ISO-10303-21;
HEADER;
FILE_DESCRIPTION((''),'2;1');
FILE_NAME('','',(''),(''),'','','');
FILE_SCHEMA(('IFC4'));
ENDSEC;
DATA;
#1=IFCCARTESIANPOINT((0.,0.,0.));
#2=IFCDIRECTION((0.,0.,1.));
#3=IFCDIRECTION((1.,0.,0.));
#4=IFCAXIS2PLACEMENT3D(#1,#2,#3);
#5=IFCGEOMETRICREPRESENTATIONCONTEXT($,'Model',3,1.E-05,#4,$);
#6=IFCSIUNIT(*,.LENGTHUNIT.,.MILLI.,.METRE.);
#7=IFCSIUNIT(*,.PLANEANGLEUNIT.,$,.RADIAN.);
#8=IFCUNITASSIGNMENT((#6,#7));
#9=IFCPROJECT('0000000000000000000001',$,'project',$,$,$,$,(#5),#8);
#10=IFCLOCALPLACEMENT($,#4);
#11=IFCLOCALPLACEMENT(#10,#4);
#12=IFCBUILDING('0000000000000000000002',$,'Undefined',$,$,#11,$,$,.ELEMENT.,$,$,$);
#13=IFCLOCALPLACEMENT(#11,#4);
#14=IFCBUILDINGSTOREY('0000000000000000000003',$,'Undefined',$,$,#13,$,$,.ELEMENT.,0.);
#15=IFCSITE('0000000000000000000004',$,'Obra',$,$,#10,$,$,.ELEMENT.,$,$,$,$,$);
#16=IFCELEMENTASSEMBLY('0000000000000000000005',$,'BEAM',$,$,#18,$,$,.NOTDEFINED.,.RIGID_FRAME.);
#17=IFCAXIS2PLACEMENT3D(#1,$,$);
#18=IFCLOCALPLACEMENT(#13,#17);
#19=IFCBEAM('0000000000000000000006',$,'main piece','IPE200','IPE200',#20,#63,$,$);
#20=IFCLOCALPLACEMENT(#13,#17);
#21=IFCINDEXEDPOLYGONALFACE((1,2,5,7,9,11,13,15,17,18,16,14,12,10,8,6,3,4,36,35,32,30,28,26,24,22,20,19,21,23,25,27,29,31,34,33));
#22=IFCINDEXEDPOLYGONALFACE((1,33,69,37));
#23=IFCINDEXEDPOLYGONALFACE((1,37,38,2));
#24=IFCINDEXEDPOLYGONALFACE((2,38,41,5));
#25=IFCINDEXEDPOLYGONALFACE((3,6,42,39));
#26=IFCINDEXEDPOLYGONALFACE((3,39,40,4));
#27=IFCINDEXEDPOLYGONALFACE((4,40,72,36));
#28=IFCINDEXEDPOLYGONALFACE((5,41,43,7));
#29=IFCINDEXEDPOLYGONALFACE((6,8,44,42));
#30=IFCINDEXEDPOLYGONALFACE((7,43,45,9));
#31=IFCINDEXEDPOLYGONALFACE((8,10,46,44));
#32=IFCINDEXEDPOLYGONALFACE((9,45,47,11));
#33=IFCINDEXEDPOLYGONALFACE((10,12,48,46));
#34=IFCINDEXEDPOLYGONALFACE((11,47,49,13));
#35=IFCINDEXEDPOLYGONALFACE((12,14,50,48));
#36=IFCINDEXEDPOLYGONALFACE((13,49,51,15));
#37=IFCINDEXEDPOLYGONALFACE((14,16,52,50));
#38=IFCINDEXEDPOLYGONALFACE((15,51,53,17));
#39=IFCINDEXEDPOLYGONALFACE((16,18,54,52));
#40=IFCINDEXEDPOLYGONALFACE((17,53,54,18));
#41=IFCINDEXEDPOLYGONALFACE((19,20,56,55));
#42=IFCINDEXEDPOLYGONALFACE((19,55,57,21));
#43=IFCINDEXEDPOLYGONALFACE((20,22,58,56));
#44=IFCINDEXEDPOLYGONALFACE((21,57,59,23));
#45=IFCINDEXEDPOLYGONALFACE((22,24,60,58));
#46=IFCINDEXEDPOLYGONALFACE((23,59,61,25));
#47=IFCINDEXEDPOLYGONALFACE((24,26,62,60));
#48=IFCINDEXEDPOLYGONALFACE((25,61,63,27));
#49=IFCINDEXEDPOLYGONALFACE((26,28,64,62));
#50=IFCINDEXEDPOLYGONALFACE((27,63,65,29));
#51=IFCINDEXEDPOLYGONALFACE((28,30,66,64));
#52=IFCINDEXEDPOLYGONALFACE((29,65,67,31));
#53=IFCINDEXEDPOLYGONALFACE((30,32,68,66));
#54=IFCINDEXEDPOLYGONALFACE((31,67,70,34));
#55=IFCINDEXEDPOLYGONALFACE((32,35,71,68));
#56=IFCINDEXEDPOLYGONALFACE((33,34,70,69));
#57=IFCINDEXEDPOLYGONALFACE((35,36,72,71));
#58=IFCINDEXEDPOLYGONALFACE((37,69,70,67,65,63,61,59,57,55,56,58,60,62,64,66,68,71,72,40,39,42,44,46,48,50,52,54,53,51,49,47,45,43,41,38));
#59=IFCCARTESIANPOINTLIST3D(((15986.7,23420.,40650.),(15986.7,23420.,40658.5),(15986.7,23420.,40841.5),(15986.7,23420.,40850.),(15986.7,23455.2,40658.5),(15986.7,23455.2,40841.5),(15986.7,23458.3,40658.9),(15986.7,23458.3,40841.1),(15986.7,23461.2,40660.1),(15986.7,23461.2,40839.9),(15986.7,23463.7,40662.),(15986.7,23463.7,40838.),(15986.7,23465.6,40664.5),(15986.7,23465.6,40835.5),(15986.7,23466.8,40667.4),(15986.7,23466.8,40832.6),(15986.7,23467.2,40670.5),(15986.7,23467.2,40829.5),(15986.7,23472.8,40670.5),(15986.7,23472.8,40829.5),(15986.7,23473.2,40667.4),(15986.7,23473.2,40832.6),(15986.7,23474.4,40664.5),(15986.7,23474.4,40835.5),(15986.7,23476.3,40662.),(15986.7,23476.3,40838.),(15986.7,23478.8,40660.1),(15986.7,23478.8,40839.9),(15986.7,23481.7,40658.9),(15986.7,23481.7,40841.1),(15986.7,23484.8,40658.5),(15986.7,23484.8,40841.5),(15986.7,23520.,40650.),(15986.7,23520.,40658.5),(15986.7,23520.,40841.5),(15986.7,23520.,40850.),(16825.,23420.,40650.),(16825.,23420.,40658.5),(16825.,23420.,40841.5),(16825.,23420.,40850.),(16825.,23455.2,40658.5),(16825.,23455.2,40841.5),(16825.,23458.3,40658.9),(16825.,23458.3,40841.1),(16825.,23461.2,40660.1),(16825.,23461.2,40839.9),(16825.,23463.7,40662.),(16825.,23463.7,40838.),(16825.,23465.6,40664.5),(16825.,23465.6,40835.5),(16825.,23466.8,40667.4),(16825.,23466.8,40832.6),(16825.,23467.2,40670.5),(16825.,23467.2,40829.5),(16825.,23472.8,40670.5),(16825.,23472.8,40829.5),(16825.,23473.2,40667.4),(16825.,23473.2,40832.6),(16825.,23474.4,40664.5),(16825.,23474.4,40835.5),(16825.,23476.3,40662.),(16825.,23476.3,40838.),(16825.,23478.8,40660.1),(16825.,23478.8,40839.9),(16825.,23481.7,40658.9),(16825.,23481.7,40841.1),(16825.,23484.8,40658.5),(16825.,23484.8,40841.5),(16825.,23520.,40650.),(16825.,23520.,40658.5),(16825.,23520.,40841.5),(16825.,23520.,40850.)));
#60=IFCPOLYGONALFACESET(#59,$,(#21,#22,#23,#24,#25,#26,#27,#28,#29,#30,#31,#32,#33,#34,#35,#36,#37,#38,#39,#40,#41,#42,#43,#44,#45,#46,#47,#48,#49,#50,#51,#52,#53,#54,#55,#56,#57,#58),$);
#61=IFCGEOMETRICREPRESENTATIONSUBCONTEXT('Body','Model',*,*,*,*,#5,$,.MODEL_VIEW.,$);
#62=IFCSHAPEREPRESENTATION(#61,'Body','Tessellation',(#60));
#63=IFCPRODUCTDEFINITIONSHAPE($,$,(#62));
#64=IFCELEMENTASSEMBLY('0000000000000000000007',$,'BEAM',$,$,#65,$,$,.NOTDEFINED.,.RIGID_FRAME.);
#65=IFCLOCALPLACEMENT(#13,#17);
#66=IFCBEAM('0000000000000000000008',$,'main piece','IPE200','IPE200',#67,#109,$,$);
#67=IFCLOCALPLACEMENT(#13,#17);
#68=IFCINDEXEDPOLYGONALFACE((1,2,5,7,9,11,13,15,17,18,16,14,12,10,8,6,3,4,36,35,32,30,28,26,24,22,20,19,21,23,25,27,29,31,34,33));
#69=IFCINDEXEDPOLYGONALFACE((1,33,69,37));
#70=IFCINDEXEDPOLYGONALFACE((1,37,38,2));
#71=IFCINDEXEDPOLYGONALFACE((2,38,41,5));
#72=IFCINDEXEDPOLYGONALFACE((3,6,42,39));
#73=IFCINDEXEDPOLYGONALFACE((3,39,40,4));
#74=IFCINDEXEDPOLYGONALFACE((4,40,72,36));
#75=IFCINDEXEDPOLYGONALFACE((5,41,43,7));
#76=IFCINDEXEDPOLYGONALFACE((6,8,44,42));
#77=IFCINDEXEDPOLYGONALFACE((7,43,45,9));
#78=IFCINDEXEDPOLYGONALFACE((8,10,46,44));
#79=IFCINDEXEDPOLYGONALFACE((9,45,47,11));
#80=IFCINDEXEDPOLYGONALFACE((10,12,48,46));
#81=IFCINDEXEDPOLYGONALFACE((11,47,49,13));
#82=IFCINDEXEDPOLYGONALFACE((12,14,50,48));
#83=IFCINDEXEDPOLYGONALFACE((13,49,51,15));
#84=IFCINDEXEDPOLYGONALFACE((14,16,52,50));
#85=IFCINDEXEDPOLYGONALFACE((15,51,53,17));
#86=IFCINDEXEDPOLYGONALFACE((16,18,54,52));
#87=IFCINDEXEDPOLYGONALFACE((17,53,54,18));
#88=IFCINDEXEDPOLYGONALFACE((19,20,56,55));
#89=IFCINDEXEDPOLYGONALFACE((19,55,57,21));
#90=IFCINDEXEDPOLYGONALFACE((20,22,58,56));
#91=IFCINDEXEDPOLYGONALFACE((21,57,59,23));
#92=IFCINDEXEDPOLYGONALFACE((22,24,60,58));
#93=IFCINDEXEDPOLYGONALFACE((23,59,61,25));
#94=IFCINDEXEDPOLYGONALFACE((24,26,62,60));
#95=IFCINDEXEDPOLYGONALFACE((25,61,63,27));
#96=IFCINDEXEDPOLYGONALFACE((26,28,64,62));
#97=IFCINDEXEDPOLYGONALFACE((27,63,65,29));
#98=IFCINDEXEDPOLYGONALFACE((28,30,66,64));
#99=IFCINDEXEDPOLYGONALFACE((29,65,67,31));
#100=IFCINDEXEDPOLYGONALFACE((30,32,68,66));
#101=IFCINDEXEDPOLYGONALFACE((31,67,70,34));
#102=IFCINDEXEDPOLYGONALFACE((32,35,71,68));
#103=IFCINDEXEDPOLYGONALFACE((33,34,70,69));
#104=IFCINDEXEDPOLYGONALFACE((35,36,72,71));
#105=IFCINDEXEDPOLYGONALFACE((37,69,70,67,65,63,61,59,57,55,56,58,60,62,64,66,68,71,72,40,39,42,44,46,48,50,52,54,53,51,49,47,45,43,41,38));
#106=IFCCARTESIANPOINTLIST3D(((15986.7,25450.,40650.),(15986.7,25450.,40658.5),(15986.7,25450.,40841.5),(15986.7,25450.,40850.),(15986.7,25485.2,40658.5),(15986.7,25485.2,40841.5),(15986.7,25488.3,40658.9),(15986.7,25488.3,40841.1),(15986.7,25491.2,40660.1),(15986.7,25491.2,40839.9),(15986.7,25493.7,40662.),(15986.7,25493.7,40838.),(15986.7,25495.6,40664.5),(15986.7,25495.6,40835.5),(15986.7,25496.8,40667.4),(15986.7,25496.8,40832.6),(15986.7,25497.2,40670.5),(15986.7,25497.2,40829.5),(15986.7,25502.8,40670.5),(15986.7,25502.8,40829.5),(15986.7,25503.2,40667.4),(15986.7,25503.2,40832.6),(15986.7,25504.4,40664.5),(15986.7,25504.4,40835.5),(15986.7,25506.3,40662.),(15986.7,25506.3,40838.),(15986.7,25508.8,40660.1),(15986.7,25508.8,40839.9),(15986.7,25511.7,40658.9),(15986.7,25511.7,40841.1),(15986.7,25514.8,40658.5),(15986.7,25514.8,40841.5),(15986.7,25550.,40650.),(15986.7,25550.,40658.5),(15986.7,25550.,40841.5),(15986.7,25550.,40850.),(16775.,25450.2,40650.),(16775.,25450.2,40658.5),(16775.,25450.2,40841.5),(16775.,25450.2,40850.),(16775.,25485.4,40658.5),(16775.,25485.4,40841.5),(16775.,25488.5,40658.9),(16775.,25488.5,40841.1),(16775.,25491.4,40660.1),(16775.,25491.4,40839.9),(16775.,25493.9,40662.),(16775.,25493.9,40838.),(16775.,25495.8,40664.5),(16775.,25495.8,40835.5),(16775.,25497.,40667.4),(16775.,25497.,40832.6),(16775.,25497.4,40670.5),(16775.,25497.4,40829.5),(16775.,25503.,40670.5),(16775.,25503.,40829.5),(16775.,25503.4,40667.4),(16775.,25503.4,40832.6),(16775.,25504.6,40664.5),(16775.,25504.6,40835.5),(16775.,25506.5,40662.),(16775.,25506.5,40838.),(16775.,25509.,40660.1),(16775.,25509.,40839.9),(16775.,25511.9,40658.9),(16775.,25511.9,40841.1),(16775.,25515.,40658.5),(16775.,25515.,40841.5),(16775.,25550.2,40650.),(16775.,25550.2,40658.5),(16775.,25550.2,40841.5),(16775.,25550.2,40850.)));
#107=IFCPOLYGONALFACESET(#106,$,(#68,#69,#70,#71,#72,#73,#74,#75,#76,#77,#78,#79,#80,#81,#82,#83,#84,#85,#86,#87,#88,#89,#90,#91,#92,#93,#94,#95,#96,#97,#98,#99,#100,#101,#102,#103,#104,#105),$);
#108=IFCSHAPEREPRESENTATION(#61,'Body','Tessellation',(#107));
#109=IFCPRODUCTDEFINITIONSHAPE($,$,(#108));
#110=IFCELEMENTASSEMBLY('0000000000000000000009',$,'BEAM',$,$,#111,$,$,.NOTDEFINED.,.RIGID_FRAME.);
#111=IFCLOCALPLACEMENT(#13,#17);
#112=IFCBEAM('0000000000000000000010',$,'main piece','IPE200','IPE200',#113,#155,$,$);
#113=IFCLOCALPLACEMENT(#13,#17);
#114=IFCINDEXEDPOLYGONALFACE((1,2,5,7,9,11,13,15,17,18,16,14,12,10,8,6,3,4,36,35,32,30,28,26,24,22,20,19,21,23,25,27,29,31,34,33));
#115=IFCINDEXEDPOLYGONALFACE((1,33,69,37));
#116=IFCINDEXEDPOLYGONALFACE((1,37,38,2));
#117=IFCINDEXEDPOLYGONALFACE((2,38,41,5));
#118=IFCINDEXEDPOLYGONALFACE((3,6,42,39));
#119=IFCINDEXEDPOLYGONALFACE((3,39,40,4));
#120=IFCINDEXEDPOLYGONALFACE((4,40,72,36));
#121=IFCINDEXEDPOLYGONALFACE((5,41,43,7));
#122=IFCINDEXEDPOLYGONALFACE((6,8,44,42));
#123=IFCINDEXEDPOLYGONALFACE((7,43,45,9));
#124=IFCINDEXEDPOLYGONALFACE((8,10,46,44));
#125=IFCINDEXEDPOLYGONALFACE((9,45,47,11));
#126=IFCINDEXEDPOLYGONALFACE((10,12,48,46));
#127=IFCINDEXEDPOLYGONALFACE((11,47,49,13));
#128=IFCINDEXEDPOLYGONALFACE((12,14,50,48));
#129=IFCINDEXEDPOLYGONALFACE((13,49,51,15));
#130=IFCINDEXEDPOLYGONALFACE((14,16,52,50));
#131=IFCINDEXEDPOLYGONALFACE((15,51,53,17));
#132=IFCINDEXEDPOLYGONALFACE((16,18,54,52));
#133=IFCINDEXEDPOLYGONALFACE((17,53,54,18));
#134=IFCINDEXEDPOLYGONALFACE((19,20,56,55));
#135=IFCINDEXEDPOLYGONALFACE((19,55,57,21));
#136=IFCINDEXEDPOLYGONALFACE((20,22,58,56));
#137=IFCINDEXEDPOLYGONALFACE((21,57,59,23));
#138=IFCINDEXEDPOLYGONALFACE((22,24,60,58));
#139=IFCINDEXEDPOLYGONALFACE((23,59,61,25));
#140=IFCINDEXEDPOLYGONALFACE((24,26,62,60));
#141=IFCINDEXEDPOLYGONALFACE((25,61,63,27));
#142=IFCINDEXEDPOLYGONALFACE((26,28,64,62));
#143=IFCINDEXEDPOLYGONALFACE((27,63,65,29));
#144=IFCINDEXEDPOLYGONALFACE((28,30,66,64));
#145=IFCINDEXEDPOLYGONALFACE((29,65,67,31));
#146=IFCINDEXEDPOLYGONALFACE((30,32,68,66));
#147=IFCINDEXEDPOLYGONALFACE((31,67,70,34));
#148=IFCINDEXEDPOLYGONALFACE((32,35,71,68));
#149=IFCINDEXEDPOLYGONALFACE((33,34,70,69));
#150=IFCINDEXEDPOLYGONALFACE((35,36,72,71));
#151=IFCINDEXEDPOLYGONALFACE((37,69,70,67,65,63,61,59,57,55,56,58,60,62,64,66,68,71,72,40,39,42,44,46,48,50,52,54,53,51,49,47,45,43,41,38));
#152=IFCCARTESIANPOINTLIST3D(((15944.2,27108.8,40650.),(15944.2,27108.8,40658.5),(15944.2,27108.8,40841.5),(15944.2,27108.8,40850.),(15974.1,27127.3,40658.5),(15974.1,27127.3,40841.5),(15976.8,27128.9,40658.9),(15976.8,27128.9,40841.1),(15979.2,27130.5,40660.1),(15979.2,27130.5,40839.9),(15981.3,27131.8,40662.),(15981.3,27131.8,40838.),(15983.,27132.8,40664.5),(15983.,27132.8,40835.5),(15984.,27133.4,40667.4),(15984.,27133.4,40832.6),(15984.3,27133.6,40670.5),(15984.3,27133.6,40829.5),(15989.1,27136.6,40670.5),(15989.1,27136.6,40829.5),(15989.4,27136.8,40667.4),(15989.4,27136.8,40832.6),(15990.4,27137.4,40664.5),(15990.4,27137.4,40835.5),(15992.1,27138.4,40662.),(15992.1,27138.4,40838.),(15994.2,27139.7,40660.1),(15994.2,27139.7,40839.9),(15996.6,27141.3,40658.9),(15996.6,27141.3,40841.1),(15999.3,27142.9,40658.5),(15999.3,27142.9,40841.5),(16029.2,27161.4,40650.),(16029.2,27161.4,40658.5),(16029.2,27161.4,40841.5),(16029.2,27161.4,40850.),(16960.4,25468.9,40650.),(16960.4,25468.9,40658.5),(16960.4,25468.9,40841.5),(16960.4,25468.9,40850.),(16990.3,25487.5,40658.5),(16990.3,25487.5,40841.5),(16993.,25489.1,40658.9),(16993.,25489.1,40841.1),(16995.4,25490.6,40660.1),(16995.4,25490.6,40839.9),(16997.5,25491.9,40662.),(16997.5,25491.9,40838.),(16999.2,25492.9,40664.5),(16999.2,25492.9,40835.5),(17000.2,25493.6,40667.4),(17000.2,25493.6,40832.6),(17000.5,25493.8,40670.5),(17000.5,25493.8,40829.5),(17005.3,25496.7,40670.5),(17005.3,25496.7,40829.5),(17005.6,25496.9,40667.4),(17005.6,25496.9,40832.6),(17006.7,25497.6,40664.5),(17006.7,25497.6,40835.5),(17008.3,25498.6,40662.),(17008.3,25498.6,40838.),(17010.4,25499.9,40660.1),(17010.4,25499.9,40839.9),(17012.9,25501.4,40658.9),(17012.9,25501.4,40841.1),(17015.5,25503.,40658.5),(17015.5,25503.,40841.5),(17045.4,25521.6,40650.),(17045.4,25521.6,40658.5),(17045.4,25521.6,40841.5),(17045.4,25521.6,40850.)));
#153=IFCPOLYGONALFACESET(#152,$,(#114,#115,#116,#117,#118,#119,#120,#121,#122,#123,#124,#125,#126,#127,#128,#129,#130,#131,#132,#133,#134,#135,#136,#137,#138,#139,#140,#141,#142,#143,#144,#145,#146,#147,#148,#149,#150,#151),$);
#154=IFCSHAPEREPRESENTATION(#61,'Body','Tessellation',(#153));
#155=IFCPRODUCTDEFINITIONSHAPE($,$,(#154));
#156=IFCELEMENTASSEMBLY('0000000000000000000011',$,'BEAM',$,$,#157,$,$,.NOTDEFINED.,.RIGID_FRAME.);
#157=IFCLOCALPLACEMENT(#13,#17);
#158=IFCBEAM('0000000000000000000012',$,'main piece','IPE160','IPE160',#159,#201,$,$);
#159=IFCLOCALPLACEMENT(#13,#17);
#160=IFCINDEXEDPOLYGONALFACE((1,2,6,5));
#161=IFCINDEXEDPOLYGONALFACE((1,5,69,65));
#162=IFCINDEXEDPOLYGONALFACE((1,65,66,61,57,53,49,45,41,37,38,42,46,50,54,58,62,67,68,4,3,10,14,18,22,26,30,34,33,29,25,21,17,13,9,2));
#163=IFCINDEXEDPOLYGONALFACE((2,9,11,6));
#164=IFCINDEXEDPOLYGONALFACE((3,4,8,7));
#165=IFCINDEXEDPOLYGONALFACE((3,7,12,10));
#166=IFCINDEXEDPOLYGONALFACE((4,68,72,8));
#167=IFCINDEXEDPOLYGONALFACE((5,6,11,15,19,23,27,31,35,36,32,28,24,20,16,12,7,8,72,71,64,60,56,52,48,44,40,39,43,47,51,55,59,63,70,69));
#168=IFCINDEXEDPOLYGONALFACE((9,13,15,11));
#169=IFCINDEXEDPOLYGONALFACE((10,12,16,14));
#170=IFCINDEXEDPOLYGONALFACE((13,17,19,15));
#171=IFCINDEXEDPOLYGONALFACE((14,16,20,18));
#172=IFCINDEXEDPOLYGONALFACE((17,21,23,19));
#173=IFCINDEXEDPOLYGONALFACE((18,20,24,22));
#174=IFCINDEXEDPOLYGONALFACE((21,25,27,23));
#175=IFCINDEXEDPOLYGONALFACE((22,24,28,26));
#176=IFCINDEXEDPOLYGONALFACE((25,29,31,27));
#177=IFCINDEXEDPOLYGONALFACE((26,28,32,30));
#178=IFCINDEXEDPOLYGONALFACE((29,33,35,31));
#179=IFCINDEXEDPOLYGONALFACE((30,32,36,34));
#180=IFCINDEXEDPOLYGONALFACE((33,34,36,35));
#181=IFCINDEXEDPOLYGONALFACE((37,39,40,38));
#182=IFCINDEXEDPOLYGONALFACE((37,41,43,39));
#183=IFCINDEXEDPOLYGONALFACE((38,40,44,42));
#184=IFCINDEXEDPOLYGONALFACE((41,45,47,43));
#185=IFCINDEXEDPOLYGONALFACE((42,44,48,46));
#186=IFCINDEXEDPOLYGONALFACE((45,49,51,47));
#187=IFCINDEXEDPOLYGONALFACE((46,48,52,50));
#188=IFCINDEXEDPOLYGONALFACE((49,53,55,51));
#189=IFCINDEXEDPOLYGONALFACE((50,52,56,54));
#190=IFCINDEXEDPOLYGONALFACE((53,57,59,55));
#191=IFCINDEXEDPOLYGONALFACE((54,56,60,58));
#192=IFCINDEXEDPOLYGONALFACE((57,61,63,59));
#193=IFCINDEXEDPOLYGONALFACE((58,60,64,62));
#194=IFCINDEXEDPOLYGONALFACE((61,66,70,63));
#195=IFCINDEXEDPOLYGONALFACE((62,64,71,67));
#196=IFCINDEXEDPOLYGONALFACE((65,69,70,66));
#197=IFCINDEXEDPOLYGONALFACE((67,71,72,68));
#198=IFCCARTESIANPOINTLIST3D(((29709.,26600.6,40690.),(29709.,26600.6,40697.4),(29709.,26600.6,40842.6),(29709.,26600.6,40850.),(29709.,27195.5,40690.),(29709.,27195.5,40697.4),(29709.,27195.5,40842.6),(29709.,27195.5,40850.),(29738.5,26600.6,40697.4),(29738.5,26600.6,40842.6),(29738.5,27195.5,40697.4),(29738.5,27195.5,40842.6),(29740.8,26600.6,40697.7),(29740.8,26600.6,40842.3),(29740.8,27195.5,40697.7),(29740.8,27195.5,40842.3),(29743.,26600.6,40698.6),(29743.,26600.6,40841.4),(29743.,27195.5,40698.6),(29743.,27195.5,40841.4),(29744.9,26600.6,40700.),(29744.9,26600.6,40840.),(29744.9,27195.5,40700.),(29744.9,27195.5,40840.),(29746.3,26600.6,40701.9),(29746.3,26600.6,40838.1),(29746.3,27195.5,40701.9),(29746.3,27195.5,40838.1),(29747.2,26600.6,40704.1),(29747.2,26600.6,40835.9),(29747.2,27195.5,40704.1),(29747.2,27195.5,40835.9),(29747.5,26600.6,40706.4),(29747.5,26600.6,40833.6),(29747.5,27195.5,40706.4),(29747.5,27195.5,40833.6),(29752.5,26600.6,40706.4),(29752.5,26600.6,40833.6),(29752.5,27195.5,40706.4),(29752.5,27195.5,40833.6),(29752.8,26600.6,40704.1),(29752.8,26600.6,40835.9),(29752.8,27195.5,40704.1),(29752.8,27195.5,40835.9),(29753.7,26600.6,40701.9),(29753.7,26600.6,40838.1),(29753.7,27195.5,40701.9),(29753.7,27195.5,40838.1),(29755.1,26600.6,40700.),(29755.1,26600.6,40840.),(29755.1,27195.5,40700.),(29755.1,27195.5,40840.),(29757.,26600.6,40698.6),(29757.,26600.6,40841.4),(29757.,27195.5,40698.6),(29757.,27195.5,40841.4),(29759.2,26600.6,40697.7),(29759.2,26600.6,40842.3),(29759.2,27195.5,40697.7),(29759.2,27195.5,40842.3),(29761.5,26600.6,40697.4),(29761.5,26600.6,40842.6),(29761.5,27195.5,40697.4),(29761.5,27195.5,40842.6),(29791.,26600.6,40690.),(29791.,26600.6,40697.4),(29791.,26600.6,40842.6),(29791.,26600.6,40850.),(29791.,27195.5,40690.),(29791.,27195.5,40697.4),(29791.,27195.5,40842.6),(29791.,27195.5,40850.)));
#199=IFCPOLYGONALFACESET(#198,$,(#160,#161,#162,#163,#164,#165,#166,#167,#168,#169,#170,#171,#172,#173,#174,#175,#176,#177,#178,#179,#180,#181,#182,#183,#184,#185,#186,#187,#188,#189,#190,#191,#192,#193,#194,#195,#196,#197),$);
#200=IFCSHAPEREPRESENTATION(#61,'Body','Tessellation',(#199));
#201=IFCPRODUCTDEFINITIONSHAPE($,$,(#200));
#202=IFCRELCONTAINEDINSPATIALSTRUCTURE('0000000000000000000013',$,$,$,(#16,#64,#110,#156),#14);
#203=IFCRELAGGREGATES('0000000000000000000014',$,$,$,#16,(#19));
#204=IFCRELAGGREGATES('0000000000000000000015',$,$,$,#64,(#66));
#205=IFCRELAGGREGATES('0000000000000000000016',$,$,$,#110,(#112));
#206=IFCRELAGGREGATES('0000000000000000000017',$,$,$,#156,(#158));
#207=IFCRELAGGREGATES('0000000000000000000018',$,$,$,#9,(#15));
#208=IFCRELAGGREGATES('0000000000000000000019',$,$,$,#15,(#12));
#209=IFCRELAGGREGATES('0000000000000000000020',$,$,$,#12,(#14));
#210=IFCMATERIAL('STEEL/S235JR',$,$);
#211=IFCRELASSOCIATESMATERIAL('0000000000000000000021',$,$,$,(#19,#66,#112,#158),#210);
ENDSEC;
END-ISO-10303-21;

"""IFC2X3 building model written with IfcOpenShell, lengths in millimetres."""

from ifc_helpers import new_model, si_unit, frame, origin_with_axes, origin_2d_with_axis, place, context, subcontext, project, spatial, i_section, extrude, material, element, aggregate, save


model = new_model("IFC2X3")

# Units and contexts
model_context = context("Model", 3, precision=1e-05, world=origin_with_axes())
body_context = subcontext(model_context, "Body", "Model", "MODEL_VIEW")
ifc_project = project(units=[si_unit("LENGTHUNIT", "METRE", prefix="MILLI"), si_unit("PLANEANGLEUNIT", "RADIAN")], contexts=[model_context])

# Site, building, storey
site_placement = place(None, origin_with_axes())
site = spatial("IfcSite", under=ifc_project, at=site_placement, Name="Obra", CompositionType="ELEMENT")
building_placement = place(site_placement, origin_with_axes())
building = spatial("IfcBuilding", under=site, at=building_placement, Name="Undefined", CompositionType="ELEMENT")
storey_placement = place(building_placement, origin_with_axes())
storey = spatial("IfcBuildingStorey", under=building, at=storey_placement, Name="Undefined", CompositionType="ELEMENT", Elevation=0.0)

# Shared definitions
ifc_material_1 = material(Name="STEEL/S235JR")

# Element assemblies, beams
assembly_1_placement = place(storey_placement, origin_with_axes())
assembly_1 = element("IfcElementAssembly", 1, at=assembly_1_placement, inside=storey, Name="BEAM", AssemblyPlace="NOTDEFINED", PredefinedType="RIGID_FRAME")
beam_1_placement = place(assembly_1_placement, frame((15986.7, 23470.0, 40750.0), z_axis=(0.0, 0.0, 1.0), x_axis=(1.0, 0.0, 0.0)))
beam_1 = element("IfcBeam", 2, at=beam_1_placement, material=ifc_material_1, Name="main piece", Description="IPE200", ObjectType="IPE200", context=body_context, shape_type="SweptSolid", body=[
    extrude(i_section(OverallWidth=100.0, OverallDepth=200.0, WebThickness=5.6, FlangeThickness=8.5, FilletRadius=12.0, at=origin_2d_with_axis()), frame((838.3, 0.0, 0.0), z_axis=(-1.0, 0.0, 0.0), x_axis=(0.0, -1.0, 0.0)), (0.0, 0.0, 1.0), 838.3),
])
aggregate(assembly_1, [beam_1])
assembly_2_placement = place(storey_placement, origin_with_axes())
assembly_2 = element("IfcElementAssembly", 3, at=assembly_2_placement, inside=storey, Name="BEAM", AssemblyPlace="NOTDEFINED", PredefinedType="RIGID_FRAME")
beam_2_placement = place(assembly_2_placement, frame((16775.0, 25500.2, 40750.0), z_axis=(0.0, 0.0, 1.0), x_axis=(-1.0, -0.000266, 0.0)))
beam_2 = element("IfcBeam", 4, at=beam_2_placement, material=ifc_material_1, Name="main piece", Description="IPE200", ObjectType="IPE200", context=body_context, shape_type="SweptSolid", body=[
    extrude(i_section(OverallWidth=100.0, OverallDepth=200.0, WebThickness=5.6, FlangeThickness=8.5, FilletRadius=12.0, at=origin_2d_with_axis()), frame((788.3, 0.0, 0.0), z_axis=(-1.0, 0.0, 0.0), x_axis=(0.0, -1.0, 0.0)), (0.0, 0.0, 1.0), 788.3),
])
aggregate(assembly_2, [beam_2])
assembly_3_placement = place(storey_placement, origin_with_axes())
assembly_3 = element("IfcElementAssembly", 5, at=assembly_3_placement, inside=storey, Name="BEAM", AssemblyPlace="NOTDEFINED", PredefinedType="RIGID_FRAME")
beam_3_placement = place(assembly_3_placement, frame((17002.9, 25495.3, 40750.0), z_axis=(0.0, 0.0, 1.0), x_axis=(-0.526756, 0.850017, 0.0)))
beam_3 = element("IfcBeam", 6, at=beam_3_placement, material=ifc_material_1, Name="main piece", Description="IPE200", ObjectType="IPE200", context=body_context, shape_type="SweptSolid", body=[
    extrude(i_section(OverallWidth=100.0, OverallDepth=200.0, WebThickness=5.6, FlangeThickness=8.5, FilletRadius=12.0, at=origin_2d_with_axis()), frame((1929.2, 0.0, 0.0), z_axis=(-1.0, 0.0, 0.0), x_axis=(0.0, -1.0, 0.0)), (0.0, 0.0, 1.0), 1929.2),
])
aggregate(assembly_3, [beam_3])
assembly_4_placement = place(storey_placement, origin_with_axes())
assembly_4 = element("IfcElementAssembly", 7, at=assembly_4_placement, inside=storey, Name="BEAM", AssemblyPlace="NOTDEFINED", PredefinedType="RIGID_FRAME")
beam_4_placement = place(assembly_4_placement, frame((29750.0, 26600.6, 40770.0), z_axis=(0.0, 0.0, 1.0), x_axis=(0.0, 1.0, 0.0)))
beam_4 = element("IfcBeam", 8, at=beam_4_placement, material=ifc_material_1, Name="main piece", Description="IPE160", ObjectType="IPE160", context=body_context, shape_type="SweptSolid", body=[
    extrude(i_section(OverallWidth=82.0, OverallDepth=160.0, WebThickness=5.0, FlangeThickness=7.4, FilletRadius=9.0, at=origin_2d_with_axis()), frame((594.9, 0.0, 0.0), z_axis=(-1.0, 0.0, 0.0), x_axis=(0.0, -1.0, 0.0)), (0.0, 0.0, 1.0), 594.9),
])
aggregate(assembly_4, [beam_4])

save(model, "model.ifc")
